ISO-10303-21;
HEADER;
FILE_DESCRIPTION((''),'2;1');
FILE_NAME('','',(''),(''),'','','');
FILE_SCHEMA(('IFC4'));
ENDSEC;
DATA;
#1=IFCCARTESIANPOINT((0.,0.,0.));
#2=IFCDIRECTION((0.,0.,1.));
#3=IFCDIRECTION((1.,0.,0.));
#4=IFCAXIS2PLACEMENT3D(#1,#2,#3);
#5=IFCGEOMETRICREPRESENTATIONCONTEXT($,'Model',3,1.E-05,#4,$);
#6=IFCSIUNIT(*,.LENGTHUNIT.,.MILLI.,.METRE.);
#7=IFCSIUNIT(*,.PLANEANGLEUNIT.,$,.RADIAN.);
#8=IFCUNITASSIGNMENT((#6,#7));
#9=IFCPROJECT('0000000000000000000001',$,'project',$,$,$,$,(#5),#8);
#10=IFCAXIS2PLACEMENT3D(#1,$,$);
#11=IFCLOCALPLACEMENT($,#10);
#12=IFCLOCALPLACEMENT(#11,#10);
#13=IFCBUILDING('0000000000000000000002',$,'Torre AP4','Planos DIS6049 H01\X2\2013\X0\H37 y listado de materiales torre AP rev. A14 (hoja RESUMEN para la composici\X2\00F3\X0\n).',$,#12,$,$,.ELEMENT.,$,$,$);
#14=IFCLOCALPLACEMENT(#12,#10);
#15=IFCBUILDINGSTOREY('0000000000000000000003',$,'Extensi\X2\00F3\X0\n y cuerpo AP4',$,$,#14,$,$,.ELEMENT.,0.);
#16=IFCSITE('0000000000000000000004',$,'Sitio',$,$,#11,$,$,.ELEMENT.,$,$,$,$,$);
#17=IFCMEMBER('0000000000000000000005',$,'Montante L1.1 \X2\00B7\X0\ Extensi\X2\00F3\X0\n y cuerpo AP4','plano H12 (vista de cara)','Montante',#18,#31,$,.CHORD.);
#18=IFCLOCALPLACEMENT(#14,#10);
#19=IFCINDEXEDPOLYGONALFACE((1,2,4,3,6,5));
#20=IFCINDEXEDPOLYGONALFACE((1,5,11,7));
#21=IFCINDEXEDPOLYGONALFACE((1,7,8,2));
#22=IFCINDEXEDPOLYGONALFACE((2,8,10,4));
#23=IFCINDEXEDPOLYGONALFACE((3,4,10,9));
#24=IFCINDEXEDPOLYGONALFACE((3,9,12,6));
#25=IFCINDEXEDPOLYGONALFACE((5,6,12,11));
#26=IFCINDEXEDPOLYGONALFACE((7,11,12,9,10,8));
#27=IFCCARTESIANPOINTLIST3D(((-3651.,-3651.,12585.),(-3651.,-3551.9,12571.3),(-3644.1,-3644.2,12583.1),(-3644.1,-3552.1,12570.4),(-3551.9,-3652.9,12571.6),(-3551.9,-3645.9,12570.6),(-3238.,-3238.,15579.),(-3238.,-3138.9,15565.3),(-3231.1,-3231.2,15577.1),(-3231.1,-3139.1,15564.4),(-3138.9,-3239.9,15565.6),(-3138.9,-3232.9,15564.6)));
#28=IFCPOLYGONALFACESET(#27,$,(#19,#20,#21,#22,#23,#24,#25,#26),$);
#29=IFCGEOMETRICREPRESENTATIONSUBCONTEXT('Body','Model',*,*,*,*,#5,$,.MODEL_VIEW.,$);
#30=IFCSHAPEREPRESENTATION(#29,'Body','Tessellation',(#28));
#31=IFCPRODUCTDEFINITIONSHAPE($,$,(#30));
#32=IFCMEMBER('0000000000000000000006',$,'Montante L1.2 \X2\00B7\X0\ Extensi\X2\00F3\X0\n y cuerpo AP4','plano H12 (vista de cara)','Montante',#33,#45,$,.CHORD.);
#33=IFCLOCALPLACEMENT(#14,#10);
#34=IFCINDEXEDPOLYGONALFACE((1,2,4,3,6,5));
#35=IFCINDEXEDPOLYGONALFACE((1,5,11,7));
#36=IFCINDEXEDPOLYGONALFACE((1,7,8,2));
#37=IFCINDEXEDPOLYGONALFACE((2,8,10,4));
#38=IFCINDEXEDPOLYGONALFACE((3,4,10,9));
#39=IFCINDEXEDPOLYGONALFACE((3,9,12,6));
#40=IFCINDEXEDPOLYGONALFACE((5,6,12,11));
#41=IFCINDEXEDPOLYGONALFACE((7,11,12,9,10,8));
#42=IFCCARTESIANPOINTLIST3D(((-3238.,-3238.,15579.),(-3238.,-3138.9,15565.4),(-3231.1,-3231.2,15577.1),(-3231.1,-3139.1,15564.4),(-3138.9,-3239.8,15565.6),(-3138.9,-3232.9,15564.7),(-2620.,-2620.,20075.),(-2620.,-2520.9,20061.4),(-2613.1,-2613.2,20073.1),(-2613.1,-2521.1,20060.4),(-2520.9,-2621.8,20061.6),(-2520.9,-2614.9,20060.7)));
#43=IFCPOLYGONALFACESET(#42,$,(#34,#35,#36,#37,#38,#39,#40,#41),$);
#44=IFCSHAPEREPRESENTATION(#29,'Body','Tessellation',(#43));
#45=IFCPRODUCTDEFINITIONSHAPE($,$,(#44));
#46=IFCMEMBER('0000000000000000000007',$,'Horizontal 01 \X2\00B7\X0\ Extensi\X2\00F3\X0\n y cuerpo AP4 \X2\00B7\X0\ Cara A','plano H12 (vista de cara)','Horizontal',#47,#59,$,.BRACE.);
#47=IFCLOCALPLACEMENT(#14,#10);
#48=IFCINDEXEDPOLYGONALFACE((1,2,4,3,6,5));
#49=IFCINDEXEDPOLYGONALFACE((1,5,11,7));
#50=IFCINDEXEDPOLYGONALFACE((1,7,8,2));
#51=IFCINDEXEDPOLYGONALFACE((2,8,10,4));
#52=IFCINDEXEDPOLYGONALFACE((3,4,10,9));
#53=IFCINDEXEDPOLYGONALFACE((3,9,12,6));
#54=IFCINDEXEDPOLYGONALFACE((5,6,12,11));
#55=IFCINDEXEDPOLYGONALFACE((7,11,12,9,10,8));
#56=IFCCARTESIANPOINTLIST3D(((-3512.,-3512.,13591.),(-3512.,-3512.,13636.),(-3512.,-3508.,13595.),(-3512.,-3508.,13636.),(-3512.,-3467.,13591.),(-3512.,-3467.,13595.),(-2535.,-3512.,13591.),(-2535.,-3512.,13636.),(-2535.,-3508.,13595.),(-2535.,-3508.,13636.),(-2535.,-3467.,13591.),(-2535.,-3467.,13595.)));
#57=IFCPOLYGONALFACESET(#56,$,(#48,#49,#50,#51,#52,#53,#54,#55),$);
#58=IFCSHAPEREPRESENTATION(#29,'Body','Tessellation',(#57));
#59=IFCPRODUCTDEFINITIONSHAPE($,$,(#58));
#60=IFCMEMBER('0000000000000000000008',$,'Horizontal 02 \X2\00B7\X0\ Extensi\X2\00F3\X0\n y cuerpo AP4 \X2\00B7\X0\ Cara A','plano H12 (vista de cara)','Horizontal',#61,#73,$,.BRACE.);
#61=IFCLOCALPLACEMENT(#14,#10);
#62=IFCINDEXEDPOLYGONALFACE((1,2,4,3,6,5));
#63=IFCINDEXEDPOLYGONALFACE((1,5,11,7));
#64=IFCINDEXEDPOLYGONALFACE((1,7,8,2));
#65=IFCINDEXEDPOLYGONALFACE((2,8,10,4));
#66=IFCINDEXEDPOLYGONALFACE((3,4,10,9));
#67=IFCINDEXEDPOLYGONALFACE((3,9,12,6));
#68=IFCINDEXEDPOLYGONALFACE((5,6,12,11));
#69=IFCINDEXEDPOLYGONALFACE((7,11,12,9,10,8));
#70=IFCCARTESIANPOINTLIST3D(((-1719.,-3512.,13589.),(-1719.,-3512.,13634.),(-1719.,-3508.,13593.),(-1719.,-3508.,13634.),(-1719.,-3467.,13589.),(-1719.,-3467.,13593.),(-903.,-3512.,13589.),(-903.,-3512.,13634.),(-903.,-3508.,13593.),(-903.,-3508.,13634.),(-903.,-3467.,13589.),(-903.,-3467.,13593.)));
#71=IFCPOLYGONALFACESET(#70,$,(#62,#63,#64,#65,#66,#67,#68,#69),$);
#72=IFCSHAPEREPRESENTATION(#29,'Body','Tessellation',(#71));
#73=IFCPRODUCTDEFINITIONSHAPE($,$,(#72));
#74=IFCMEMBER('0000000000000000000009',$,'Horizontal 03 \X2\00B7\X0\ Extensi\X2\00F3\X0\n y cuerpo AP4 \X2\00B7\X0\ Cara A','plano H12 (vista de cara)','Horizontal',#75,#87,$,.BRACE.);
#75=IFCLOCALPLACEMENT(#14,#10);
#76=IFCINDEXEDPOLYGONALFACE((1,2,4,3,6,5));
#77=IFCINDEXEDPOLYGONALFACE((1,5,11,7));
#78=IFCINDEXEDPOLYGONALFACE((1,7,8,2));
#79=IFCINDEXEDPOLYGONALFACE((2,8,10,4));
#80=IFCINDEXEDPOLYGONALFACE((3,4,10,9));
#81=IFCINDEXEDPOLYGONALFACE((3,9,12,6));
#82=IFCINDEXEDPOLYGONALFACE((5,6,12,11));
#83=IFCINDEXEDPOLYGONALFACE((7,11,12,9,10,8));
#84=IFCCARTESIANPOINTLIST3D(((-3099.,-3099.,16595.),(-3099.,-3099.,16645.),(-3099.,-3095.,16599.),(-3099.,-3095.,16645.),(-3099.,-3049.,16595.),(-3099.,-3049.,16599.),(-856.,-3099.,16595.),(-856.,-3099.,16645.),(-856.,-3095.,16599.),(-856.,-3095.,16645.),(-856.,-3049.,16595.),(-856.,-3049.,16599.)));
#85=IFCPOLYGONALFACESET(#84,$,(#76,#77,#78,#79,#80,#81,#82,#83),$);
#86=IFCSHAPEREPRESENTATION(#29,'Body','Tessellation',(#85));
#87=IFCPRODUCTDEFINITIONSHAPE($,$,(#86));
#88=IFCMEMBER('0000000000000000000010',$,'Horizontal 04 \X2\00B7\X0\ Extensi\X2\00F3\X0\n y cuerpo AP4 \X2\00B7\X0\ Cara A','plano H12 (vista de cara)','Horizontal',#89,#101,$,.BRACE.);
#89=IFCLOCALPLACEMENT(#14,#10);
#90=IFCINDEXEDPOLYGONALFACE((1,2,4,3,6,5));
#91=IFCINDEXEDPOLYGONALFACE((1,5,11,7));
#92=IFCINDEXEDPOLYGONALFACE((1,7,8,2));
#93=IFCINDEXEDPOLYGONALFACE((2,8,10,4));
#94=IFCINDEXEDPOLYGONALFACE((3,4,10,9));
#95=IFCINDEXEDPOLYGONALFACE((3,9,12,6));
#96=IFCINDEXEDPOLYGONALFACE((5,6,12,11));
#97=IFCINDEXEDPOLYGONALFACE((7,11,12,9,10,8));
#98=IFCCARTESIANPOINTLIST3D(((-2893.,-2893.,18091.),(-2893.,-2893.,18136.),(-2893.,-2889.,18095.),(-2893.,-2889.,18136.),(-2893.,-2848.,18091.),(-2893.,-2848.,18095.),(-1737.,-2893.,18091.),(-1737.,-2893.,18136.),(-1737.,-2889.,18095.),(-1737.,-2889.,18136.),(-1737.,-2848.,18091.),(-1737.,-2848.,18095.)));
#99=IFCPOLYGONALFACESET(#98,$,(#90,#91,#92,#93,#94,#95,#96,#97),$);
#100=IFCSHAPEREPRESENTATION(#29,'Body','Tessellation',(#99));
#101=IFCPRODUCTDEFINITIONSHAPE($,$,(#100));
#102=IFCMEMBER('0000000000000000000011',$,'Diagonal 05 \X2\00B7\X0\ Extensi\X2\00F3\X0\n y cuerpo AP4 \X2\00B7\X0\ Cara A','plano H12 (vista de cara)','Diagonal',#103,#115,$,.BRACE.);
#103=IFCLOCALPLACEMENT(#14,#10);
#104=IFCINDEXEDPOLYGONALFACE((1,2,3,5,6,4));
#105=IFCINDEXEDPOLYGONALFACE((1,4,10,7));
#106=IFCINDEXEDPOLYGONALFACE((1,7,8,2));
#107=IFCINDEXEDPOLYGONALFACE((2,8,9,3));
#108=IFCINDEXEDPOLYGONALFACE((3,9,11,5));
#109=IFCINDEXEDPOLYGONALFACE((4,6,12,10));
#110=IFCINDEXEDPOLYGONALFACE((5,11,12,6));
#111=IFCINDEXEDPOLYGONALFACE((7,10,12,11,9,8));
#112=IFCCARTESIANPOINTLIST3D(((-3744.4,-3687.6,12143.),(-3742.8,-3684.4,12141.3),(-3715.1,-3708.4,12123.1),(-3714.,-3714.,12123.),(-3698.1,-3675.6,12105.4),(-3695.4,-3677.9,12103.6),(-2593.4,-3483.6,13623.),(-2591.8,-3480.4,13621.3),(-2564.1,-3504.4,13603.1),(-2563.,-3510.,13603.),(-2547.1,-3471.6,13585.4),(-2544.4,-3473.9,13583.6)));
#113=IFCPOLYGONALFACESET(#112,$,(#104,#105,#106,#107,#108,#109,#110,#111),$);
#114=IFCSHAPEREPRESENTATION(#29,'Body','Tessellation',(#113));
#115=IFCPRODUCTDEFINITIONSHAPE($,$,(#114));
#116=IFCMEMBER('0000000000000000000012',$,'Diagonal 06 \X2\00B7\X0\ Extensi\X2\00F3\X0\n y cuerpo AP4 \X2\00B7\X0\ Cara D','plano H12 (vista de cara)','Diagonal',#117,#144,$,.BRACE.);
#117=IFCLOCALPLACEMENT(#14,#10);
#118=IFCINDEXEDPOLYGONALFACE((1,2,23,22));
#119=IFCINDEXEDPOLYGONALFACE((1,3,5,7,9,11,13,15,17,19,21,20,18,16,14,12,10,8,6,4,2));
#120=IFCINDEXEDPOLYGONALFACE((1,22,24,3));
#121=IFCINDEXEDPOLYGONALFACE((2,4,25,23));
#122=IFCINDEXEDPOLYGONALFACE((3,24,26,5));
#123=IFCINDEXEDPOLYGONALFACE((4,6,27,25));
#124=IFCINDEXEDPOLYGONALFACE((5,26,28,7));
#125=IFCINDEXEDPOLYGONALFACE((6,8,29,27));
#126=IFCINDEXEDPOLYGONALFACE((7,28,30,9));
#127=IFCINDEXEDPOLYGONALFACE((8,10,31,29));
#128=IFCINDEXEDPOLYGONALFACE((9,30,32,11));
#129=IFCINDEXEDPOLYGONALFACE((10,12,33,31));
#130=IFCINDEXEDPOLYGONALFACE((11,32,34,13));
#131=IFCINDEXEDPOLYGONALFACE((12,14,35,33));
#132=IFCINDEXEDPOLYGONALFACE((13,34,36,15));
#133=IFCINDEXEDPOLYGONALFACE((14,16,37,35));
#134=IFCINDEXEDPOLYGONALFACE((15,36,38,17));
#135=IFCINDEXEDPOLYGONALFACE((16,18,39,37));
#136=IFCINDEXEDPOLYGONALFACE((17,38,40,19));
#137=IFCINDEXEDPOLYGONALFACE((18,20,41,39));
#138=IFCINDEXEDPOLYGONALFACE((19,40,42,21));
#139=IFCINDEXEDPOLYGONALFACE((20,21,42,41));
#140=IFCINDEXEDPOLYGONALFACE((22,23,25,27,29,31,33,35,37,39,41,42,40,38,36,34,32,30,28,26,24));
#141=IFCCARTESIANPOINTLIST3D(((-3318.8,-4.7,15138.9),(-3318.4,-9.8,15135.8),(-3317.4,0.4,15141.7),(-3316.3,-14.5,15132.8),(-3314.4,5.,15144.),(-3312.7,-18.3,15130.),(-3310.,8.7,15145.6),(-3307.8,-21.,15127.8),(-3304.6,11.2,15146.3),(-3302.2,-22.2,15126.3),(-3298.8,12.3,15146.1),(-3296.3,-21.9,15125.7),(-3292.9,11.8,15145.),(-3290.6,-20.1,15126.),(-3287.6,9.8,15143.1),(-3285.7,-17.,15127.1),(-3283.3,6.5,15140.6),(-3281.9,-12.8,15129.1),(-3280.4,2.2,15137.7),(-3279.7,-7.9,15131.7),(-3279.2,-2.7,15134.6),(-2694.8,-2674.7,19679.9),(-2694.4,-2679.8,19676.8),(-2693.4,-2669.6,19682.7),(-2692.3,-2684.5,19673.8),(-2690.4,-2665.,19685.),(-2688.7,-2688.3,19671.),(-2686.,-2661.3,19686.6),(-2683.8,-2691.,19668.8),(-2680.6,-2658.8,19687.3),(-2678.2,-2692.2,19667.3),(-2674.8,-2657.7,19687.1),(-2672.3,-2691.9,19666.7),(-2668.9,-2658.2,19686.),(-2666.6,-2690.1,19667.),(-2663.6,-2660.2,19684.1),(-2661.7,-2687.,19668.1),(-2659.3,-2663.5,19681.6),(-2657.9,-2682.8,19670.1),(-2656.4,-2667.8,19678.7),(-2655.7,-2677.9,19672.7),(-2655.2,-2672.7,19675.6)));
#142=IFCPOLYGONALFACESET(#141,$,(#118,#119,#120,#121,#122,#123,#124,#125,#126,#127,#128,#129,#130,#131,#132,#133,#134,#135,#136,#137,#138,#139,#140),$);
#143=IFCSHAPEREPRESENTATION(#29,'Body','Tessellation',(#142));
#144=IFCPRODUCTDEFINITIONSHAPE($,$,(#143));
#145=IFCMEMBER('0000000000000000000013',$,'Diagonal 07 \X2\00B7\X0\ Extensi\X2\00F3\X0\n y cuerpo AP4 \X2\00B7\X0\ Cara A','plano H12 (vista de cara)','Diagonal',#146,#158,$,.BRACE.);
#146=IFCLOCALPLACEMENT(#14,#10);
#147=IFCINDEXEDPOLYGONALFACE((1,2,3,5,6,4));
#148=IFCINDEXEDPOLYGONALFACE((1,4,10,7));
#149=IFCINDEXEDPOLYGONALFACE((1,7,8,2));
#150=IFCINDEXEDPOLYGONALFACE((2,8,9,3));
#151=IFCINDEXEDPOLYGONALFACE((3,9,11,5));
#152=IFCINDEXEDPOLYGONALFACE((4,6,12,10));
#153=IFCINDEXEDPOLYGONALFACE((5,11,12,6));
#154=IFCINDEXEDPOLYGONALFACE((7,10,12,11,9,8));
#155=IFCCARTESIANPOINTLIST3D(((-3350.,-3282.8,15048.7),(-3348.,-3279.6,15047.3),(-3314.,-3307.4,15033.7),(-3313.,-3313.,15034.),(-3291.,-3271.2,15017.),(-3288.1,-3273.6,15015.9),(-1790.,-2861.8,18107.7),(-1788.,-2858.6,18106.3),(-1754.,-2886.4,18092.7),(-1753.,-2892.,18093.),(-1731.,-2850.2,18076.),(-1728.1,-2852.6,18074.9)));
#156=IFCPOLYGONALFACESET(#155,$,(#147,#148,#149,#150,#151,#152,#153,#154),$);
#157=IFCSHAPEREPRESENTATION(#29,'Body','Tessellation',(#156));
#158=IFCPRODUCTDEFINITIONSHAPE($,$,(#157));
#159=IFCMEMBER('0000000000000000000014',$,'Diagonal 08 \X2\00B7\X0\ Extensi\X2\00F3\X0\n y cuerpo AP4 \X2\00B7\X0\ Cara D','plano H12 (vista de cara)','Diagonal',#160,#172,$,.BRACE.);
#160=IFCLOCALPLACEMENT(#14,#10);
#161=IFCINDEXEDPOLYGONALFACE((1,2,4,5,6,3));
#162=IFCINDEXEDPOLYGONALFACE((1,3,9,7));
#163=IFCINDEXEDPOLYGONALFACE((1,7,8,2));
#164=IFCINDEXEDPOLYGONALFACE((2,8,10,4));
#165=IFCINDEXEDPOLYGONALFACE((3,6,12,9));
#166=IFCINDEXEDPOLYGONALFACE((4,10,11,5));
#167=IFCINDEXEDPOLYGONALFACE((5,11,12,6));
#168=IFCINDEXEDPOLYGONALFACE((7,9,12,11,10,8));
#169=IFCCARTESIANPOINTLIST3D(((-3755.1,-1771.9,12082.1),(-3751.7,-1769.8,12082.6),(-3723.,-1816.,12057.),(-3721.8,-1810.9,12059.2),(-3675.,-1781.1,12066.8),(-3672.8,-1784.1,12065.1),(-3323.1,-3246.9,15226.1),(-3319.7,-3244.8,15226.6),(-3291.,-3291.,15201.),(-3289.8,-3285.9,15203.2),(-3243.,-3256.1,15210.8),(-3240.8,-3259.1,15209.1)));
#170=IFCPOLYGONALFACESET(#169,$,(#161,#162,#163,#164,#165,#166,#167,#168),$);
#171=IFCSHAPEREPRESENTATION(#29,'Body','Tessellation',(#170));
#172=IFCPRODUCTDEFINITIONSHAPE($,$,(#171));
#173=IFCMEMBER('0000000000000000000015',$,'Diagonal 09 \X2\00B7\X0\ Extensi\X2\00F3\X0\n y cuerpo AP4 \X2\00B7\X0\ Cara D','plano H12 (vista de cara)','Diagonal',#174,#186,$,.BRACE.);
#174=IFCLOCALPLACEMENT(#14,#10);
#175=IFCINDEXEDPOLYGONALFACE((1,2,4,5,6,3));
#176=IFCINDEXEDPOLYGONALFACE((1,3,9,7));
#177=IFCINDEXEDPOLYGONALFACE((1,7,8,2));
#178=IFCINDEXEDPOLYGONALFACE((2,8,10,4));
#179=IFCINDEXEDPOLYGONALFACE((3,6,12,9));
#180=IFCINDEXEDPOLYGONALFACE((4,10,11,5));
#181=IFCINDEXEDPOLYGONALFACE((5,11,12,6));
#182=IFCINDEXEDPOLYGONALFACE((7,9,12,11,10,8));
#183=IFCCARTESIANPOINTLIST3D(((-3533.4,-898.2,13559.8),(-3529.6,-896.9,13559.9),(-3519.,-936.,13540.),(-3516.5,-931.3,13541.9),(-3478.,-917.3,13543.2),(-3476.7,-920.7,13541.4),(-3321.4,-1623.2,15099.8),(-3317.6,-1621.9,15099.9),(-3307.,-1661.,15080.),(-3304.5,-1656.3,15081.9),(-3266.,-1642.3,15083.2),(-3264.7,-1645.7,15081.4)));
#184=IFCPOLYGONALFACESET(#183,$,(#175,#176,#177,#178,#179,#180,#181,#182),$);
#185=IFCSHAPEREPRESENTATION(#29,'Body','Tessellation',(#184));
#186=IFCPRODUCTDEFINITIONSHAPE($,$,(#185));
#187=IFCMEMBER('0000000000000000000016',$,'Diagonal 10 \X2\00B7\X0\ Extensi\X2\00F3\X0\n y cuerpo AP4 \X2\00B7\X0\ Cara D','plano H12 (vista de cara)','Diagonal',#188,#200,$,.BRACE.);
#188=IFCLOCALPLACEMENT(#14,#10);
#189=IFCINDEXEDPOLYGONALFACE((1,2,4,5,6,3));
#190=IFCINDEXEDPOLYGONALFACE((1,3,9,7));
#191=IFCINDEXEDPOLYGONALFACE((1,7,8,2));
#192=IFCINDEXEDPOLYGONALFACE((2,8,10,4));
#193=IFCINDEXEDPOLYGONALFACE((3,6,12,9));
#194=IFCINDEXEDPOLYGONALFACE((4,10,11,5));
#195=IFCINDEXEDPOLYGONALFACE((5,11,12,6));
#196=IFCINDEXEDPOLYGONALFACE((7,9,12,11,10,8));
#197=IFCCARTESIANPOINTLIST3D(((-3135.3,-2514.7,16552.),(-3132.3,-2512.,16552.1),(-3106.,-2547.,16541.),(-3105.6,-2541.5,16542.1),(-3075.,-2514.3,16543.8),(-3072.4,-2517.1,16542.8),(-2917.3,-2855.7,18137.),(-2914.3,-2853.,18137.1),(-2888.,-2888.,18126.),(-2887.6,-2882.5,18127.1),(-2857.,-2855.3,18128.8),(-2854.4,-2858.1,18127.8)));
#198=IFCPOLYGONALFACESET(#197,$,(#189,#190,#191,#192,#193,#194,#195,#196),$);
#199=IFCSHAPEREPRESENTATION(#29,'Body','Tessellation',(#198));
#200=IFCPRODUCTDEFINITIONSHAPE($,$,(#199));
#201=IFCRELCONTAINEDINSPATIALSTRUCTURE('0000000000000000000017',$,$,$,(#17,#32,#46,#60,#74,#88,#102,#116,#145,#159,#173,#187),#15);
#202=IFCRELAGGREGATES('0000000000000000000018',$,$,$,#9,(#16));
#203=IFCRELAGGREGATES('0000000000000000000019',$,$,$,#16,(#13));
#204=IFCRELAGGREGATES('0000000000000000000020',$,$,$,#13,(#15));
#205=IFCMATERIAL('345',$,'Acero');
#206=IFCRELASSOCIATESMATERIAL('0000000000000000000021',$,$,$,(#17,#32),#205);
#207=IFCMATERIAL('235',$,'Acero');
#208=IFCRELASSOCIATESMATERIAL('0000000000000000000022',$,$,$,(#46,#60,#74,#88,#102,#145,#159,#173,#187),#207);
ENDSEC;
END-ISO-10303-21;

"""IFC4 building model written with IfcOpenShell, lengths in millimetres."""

from ifc_helpers import new_model, si_unit, frame, frame_2d, origin, origin_with_axes, place, context, subcontext, project, spatial, circle, l_section, extrude, material, element, save


model = new_model("IFC4")

# Units and contexts
model_context = context("Model", 3, precision=1e-05, world=origin_with_axes())
body_context = subcontext(model_context, "Body", "Model", "MODEL_VIEW")
ifc_project = project(units=[si_unit("LENGTHUNIT", "METRE", prefix="MILLI"), si_unit("PLANEANGLEUNIT", "RADIAN")], contexts=[model_context])

# Site, building, storey
site_placement = place(None, origin())
site = spatial("IfcSite", under=ifc_project, at=site_placement, Name="Sitio", CompositionType="ELEMENT")
building_placement = place(site_placement, origin())
building = spatial("IfcBuilding", under=site, at=building_placement, Name="Torre AP4", Description="Planos DIS6049 H01–H37 y listado de materiales torre AP rev. A14 (hoja RESUMEN para la composición).", CompositionType="ELEMENT")
storey_placement = place(building_placement, origin())
storey = spatial("IfcBuildingStorey", under=building, at=storey_placement, Name="Extensión y cuerpo AP4", CompositionType="ELEMENT", Elevation=0.0)

# Members
ifc_material_1 = material(Name="345", Category="Acero")
member_1_placement = place(storey_placement, frame((-3651.0, -3651.0, 12585.0), z_axis=(0.13539, 0.13539, 0.981498), x_axis=(0.990792, -0.018501, -0.13412)))
element("IfcMember", 1, at=member_1_placement, inside=storey, material=ifc_material_1, Name="Montante L1.1 · Extensión y cuerpo AP4", Description="plano H12 (vista de cara)", ObjectType="Montante", PredefinedType="CHORD", context=body_context, shape_type="SweptSolid", body=[
    extrude(l_section(Depth=100.0, Width=100.0, Thickness=7.0, at=frame_2d((50.0, 50.0))), None, (0.0, 0.0, 1.0), 3050.4),
])
member_2_placement = place(storey_placement, frame((-3238.0, -3238.0, 15579.0), z_axis=(0.13493, 0.13493, 0.981625), x_axis=(0.990855, -0.018374, -0.133673)))
element("IfcMember", 2, at=member_2_placement, inside=storey, material=ifc_material_1, Name="Montante L1.2 · Extensión y cuerpo AP4", Description="plano H12 (vista de cara)", ObjectType="Montante", PredefinedType="CHORD", context=body_context, shape_type="SweptSolid", body=[
    extrude(l_section(Depth=100.0, Width=100.0, Thickness=7.0, at=frame_2d((50.0, 50.0))), None, (0.0, 0.0, 1.0), 4580.2),
])
ifc_material_2 = material(Name="235", Category="Acero")
member_3_placement = place(storey_placement, frame((-3512.0, -3512.0, 13591.0), z_axis=(1.0, 0.0, 0.0), x_axis=(0.0, 1.0, 0.0)))
element("IfcMember", 3, at=member_3_placement, inside=storey, material=ifc_material_2, Name="Horizontal 01 · Extensión y cuerpo AP4 · Cara A", Description="plano H12 (vista de cara)", ObjectType="Horizontal", PredefinedType="BRACE", context=body_context, shape_type="SweptSolid", body=[
    extrude(l_section(Depth=45.0, Width=45.0, Thickness=4.0, at=frame_2d((22.5, 22.5))), None, (0.0, 0.0, 1.0), 977.0),
])
member_4_placement = place(storey_placement, frame((-1719.0, -3512.0, 13589.0), z_axis=(1.0, 0.0, 0.0), x_axis=(0.0, 1.0, 0.0)))
element("IfcMember", 4, at=member_4_placement, inside=storey, material=ifc_material_2, Name="Horizontal 02 · Extensión y cuerpo AP4 · Cara A", Description="plano H12 (vista de cara)", ObjectType="Horizontal", PredefinedType="BRACE", context=body_context, shape_type="SweptSolid", body=[
    extrude(l_section(Depth=45.0, Width=45.0, Thickness=4.0, at=frame_2d((22.5, 22.5))), None, (0.0, 0.0, 1.0), 816.0),
])
member_5_placement = place(storey_placement, frame((-3099.0, -3099.0, 16595.0), z_axis=(1.0, 0.0, 0.0), x_axis=(0.0, 1.0, 0.0)))
element("IfcMember", 5, at=member_5_placement, inside=storey, material=ifc_material_2, Name="Horizontal 03 · Extensión y cuerpo AP4 · Cara A", Description="plano H12 (vista de cara)", ObjectType="Horizontal", PredefinedType="BRACE", context=body_context, shape_type="SweptSolid", body=[
    extrude(l_section(Depth=50.0, Width=50.0, Thickness=4.0, at=frame_2d((25.0, 25.0))), None, (0.0, 0.0, 1.0), 2243.0),
])
member_6_placement = place(storey_placement, frame((-2893.0, -2893.0, 18091.0), z_axis=(1.0, 0.0, 0.0), x_axis=(0.0, 1.0, 0.0)))
element("IfcMember", 6, at=member_6_placement, inside=storey, material=ifc_material_2, Name="Horizontal 04 · Extensión y cuerpo AP4 · Cara A", Description="plano H12 (vista de cara)", ObjectType="Horizontal", PredefinedType="BRACE", context=body_context, shape_type="SweptSolid", body=[
    extrude(l_section(Depth=45.0, Width=45.0, Thickness=4.0, at=frame_2d((22.5, 22.5))), None, (0.0, 0.0, 1.0), 1156.0),
])
member_7_placement = place(storey_placement, frame((-3714.0, -3714.0, 12123.0), z_axis=(0.610302, 0.108168, 0.784749), x_axis=(0.412878, 0.802007, -0.431644)))
element("IfcMember", 7, at=member_7_placement, inside=storey, material=ifc_material_2, Name="Diagonal 05 · Extensión y cuerpo AP4 · Cara A", Description="plano H12 (vista de cara)", ObjectType="Diagonal", PredefinedType="BRACE", context=body_context, shape_type="SweptSolid", body=[
    extrude(l_section(Depth=45.0, Width=45.0, Thickness=4.0, at=frame_2d((22.5, 22.5))), None, (0.0, 0.0, 1.0), 1886.0),
])
member_8_placement = place(storey_placement, frame((-3299.0, -5.0, 15136.0), z_axis=(0.117633, -0.503335, 0.856047), x_axis=(0.928538, 0.361399, 0.0849)))
element("IfcMember", 8, at=member_8_placement, inside=storey, Name="Diagonal 06 · Extensión y cuerpo AP4 · Cara D", Description="plano H12 (vista de cara)", ObjectType="Diagonal", PredefinedType="BRACE", context=body_context, shape_type="SweptSolid", body=[
    extrude(circle(Radius=20.0), None, (0.0, 0.0, 1.0), 5304.6),
])
member_9_placement = place(storey_placement, frame((-3313.0, -3313.0, 15034.0), z_axis=(0.450929, 0.121693, 0.884225), x_axis=(0.498615, 0.787324, -0.362636)))
element("IfcMember", 9, at=member_9_placement, inside=storey, material=ifc_material_2, Name="Diagonal 07 · Extensión y cuerpo AP4 · Cara A", Description="plano H12 (vista de cara)", ObjectType="Diagonal", PredefinedType="BRACE", context=body_context, shape_type="SweptSolid", body=[
    extrude(l_section(Depth=50.0, Width=50.0, Thickness=4.0, at=frame_2d((25.0, 25.0))), None, (0.0, 0.0, 1.0), 3459.5),
])
member_10_placement = place(storey_placement, frame((-3723.0, -1816.0, 12057.0), z_axis=(0.123444, -0.42148, 0.898396), x_axis=(0.835962, 0.531995, 0.134719)))
element("IfcMember", 10, at=member_10_placement, inside=storey, material=ifc_material_2, Name="Diagonal 08 · Extensión y cuerpo AP4 · Cara D", Description="plano H12 (vista de cara)", ObjectType="Diagonal", PredefinedType="BRACE", context=body_context, shape_type="SweptSolid", body=[
    extrude(l_section(Depth=60.0, Width=60.0, Thickness=4.0, at=frame_2d((30.0, 30.0))), None, (0.0, 0.0, 1.0), 3499.6),
])
member_11_placement = place(storey_placement, frame((-3519.0, -936.0, 13540.0), z_axis=(0.123595, -0.422673, 0.897815), x_axis=(0.939509, 0.341096, 0.031246)))
element("IfcMember", 11, at=member_11_placement, inside=storey, material=ifc_material_2, Name="Diagonal 09 · Extensión y cuerpo AP4 · Cara D", Description="plano H12 (vista de cara)", ObjectType="Diagonal", PredefinedType="BRACE", context=body_context, shape_type="SweptSolid", body=[
    extrude(l_section(Depth=45.0, Width=45.0, Thickness=4.0, at=frame_2d((22.5, 22.5))), None, (0.0, 0.0, 1.0), 1715.3),
])
member_12_placement = place(storey_placement, frame((-3106.0, -2547.0, 16541.0), z_axis=(0.133263, -0.208453, 0.968911), x_axis=(0.746947, 0.663676, 0.04005)))
element("IfcMember", 12, at=member_12_placement, inside=storey, material=ifc_material_2, Name="Diagonal 10 · Extensión y cuerpo AP4 · Cara D", Description="plano H12 (vista de cara)", ObjectType="Diagonal", PredefinedType="BRACE", context=body_context, shape_type="SweptSolid", body=[
    extrude(l_section(Depth=45.0, Width=45.0, Thickness=4.0, at=frame_2d((22.5, 22.5))), None, (0.0, 0.0, 1.0), 1635.9),
])

save(model, "model.ifc")
